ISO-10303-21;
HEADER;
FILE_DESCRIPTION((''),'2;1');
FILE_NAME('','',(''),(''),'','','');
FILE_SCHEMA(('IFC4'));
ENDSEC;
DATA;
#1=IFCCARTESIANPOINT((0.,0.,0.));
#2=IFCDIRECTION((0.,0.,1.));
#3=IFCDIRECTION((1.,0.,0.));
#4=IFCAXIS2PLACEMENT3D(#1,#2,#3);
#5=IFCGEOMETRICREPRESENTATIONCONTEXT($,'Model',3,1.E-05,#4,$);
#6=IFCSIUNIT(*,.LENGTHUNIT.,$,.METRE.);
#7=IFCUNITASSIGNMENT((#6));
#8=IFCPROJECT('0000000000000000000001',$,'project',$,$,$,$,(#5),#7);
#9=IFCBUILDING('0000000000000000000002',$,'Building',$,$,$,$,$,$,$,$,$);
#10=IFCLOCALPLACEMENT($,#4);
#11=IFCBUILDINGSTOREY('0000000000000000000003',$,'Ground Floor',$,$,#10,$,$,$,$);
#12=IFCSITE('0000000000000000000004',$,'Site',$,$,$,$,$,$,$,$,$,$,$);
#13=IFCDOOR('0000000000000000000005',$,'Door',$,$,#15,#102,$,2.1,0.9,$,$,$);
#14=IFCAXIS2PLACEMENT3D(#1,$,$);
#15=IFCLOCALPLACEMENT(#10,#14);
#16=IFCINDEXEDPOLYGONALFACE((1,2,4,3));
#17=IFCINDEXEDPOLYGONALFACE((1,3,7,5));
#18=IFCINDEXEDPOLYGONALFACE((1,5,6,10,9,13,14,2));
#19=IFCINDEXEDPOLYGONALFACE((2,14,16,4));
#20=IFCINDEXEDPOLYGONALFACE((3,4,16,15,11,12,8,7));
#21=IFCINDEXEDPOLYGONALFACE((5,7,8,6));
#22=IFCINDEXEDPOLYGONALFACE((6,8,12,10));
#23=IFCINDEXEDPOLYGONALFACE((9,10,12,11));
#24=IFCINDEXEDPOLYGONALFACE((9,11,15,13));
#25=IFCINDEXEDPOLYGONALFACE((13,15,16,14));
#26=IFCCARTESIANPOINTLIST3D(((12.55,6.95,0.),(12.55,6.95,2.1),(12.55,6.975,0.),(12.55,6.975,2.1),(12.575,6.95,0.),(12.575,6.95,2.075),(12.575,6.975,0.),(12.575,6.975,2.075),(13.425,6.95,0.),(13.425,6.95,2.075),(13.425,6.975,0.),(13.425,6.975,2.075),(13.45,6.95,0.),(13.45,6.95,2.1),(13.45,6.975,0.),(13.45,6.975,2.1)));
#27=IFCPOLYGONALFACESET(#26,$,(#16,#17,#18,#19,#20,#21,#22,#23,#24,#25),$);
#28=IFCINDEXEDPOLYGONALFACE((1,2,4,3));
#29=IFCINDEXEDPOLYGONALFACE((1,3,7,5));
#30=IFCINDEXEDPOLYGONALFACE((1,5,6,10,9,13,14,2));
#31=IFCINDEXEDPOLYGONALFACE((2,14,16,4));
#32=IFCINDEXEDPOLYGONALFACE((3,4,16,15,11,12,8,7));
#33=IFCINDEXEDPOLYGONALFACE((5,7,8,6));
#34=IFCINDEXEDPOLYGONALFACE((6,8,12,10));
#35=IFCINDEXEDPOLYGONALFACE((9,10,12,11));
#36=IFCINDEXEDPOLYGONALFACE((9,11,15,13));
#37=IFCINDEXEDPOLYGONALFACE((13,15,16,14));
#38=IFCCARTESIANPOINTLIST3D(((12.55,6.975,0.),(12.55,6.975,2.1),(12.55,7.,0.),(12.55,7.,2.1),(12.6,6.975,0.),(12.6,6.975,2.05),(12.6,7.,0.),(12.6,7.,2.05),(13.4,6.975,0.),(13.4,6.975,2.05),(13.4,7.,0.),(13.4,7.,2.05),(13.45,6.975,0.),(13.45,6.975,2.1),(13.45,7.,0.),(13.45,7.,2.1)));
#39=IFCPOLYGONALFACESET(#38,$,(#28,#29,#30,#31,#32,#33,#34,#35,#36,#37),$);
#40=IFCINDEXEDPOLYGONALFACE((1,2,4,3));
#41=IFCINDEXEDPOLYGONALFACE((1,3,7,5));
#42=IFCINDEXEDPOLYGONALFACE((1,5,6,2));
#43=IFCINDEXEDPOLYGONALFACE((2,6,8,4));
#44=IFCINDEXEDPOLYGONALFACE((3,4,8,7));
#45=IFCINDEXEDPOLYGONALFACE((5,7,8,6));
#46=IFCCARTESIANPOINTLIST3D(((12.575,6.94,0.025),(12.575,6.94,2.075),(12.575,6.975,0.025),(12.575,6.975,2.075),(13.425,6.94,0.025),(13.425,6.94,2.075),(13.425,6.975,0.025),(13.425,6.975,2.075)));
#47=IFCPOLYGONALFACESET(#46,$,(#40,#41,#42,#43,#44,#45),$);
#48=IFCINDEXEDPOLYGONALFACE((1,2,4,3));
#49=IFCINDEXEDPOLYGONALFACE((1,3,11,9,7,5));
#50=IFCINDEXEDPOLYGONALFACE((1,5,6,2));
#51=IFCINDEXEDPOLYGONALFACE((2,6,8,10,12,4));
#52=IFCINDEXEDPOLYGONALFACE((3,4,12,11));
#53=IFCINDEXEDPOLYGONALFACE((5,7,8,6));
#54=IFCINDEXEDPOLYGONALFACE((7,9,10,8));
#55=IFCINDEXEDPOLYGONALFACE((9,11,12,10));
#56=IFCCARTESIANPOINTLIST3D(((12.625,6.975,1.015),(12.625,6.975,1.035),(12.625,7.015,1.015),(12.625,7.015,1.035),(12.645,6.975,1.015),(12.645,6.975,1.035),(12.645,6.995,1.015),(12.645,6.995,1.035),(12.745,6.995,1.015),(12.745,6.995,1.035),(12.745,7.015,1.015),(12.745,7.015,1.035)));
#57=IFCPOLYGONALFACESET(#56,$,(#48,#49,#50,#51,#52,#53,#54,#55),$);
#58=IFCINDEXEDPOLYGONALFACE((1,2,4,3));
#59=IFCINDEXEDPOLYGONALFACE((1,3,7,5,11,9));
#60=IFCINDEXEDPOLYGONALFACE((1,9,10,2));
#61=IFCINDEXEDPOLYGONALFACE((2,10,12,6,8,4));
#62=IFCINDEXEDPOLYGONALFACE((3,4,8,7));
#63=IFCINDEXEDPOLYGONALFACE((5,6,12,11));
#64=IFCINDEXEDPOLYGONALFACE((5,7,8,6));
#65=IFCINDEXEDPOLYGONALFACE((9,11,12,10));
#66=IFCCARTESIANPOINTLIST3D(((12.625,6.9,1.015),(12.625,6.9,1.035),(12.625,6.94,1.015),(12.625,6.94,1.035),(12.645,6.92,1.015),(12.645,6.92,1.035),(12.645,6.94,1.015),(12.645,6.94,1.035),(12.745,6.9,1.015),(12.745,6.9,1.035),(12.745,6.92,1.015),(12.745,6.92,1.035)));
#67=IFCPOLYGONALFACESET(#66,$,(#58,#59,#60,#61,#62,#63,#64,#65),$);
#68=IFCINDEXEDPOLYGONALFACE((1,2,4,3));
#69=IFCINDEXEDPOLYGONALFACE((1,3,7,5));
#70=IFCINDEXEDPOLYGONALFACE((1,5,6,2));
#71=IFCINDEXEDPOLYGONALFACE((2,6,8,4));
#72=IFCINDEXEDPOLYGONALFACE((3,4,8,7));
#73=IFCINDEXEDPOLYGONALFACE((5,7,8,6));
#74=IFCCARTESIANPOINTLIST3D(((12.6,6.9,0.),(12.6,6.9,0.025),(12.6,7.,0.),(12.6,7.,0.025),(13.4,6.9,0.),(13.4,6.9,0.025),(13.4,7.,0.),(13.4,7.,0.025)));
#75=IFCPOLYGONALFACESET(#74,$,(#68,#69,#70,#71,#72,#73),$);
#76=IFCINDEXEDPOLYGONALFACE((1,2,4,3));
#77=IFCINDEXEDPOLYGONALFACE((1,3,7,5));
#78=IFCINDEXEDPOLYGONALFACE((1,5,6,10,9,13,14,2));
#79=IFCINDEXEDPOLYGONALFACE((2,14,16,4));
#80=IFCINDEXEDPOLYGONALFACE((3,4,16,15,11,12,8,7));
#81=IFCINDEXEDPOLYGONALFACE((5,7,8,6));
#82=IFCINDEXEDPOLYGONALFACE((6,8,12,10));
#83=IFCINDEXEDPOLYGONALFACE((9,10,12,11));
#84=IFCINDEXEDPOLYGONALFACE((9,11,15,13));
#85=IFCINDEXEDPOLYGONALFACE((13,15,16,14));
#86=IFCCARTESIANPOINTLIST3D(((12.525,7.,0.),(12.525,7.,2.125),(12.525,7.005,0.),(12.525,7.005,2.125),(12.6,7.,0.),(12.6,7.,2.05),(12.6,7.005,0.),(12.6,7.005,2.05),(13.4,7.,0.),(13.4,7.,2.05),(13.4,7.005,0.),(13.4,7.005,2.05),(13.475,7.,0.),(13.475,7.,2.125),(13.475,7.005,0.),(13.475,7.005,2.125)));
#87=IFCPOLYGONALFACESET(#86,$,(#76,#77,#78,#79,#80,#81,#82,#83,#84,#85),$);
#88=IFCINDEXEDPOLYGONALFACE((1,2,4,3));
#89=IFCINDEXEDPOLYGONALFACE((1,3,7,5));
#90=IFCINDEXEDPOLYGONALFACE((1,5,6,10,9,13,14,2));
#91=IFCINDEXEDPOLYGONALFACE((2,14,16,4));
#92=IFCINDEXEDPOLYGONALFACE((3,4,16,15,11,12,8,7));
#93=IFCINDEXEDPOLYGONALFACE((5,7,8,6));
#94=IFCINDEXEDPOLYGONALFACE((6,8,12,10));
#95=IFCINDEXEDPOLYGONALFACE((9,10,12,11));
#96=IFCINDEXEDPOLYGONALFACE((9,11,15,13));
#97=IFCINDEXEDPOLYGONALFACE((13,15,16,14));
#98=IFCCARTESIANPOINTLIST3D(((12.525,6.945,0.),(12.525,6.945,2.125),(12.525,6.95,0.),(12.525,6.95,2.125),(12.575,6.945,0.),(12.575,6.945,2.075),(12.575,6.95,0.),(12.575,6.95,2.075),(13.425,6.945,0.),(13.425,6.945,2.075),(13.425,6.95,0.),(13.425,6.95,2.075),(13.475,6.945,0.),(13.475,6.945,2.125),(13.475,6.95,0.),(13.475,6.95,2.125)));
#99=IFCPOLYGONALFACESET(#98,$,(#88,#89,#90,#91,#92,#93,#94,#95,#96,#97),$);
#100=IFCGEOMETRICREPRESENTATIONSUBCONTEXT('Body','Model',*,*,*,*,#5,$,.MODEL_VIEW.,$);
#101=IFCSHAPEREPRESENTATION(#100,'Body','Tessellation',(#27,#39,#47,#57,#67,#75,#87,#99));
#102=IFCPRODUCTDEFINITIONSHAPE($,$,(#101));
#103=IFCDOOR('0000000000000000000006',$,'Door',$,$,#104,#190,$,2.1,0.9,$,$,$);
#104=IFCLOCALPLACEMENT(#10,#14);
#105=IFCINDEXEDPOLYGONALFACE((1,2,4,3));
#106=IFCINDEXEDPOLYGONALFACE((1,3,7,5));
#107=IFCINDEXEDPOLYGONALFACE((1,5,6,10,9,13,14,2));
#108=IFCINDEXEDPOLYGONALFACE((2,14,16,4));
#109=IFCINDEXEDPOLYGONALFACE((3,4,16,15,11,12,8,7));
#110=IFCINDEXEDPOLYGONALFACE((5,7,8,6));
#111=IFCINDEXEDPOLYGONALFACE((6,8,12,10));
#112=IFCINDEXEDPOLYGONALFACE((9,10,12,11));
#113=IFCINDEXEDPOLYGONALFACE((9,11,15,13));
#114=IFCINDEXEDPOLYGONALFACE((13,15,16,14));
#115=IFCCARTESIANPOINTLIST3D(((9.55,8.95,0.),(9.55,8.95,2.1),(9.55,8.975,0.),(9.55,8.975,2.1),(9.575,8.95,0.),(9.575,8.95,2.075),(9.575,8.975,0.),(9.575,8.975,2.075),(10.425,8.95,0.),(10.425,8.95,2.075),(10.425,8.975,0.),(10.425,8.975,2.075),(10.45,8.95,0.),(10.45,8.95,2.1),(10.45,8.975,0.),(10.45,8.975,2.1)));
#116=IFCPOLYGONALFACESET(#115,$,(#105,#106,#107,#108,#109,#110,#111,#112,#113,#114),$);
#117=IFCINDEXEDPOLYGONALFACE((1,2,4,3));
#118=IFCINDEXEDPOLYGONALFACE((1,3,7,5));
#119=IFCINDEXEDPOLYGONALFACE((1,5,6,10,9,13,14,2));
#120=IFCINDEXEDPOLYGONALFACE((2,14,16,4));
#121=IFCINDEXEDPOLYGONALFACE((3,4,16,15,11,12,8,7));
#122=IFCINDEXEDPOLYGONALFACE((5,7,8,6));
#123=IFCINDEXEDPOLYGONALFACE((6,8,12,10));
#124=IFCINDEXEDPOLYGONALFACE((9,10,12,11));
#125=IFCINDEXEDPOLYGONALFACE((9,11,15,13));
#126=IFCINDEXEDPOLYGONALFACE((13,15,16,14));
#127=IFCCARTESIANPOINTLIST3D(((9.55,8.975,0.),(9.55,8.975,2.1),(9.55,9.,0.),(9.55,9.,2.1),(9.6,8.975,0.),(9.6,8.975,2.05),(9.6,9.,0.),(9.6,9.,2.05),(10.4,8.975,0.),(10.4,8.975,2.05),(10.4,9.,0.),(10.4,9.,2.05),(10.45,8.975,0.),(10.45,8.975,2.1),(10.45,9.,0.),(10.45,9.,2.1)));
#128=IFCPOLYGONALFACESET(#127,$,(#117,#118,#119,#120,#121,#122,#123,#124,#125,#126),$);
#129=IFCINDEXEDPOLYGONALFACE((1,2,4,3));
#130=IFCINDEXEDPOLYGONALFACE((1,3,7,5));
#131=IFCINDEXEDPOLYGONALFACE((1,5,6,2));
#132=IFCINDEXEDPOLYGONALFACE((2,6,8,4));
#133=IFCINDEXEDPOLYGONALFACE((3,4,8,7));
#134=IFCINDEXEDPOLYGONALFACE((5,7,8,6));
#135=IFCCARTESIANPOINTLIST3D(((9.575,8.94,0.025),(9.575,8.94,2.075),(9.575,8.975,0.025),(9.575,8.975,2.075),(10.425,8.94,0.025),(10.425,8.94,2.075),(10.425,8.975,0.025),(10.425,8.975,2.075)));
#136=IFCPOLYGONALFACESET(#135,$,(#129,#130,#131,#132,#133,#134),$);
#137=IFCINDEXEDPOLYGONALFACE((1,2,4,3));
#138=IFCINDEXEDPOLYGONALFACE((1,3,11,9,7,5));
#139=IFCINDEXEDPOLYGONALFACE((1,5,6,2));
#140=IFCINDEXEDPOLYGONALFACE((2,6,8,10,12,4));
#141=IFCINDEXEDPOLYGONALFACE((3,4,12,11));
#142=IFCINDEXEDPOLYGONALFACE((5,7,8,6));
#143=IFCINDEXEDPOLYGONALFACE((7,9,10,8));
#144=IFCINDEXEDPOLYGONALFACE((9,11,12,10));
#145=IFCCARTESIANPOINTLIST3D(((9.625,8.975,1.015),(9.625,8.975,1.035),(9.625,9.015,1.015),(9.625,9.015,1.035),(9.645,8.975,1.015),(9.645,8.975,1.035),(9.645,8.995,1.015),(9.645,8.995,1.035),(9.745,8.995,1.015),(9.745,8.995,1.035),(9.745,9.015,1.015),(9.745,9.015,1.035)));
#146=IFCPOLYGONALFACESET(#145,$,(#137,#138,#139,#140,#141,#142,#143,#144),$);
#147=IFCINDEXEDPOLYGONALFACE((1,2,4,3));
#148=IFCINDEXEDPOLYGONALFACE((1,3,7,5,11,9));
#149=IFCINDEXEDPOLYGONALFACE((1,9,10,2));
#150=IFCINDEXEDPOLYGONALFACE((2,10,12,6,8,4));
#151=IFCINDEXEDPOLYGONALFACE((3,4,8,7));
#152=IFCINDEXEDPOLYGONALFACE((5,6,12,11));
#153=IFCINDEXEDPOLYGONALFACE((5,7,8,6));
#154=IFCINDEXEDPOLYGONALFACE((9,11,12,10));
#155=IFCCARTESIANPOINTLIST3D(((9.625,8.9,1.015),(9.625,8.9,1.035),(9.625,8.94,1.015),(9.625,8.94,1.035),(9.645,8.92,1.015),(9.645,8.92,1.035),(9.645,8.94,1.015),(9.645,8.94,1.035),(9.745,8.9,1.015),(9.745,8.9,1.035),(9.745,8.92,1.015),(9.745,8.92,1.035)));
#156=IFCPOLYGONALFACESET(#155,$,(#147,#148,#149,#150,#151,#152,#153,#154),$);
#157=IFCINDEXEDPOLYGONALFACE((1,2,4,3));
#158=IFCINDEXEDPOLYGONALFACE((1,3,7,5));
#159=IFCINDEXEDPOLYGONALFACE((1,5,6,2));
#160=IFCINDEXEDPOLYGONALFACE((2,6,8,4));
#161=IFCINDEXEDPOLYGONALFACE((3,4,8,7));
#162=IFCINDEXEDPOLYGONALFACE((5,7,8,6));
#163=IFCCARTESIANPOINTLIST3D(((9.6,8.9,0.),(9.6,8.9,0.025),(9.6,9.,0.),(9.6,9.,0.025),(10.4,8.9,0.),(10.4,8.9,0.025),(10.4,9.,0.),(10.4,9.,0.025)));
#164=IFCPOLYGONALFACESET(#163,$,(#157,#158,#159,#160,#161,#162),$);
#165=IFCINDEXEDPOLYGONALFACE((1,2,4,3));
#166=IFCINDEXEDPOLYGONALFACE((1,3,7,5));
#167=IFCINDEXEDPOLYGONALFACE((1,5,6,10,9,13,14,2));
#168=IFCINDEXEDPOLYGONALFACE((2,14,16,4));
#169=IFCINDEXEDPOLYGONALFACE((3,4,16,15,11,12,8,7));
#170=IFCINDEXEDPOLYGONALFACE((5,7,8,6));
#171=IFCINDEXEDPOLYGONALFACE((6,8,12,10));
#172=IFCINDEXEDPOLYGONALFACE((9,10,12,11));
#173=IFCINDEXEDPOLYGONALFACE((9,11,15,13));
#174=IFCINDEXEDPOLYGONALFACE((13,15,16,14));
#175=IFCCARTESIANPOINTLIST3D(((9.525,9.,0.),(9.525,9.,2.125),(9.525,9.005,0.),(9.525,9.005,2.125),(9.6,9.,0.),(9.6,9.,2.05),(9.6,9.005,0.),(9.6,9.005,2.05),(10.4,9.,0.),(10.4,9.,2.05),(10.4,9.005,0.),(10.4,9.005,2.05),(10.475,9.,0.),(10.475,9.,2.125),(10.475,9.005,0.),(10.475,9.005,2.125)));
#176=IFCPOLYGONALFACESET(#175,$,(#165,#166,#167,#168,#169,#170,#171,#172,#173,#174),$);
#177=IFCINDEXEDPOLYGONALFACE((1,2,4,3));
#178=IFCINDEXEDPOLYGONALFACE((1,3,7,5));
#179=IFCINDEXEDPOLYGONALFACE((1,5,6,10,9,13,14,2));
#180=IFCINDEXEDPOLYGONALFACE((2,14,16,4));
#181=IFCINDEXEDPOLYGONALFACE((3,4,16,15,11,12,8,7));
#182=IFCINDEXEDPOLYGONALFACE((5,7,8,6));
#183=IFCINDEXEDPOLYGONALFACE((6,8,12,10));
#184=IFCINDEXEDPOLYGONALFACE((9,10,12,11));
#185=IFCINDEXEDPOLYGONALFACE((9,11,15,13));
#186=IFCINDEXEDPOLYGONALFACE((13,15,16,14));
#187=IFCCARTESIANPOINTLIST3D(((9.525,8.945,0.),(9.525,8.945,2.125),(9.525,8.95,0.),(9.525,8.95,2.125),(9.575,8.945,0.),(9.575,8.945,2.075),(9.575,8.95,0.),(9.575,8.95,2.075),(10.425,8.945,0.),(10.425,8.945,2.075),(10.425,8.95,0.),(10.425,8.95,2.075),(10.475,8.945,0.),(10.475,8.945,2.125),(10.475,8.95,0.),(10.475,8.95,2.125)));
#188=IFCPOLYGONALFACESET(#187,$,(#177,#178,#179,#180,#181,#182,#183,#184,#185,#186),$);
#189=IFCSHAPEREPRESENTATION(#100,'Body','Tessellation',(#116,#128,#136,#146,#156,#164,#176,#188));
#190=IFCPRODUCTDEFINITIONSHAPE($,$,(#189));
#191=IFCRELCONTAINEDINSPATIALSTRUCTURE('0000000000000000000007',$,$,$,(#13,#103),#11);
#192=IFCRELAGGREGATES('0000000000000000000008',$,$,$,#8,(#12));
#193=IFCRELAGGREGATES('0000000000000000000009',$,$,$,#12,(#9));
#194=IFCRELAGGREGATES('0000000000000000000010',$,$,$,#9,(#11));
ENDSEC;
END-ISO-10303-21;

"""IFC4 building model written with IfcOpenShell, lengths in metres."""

from ifc_helpers import new_model, si_unit, frame, origin_with_axes, place, context, subcontext, project, spatial, line, indexed_curve, outline, extrude, element, save


model = new_model("IFC4")

# Units and contexts
model_context = context("Model", 3, precision=1e-05, world=origin_with_axes())
body_context = subcontext(model_context, "Body", "Model", "MODEL_VIEW")
ifc_project = project(units=[si_unit("LENGTHUNIT", "METRE")], contexts=[model_context])

# Site, building, storey
site = spatial("IfcSite", under=ifc_project, Name="Site")
building = spatial("IfcBuilding", under=site, Name="Building")
storey_placement = place(None, origin_with_axes())
storey = spatial("IfcBuildingStorey", under=building, at=storey_placement, Name="Ground Floor")

# Doors
door_1_placement = place(storey_placement, frame((13.45, 7.0, 0.0), z_axis=(0.0, 0.0, 1.0), x_axis=(-1.0, 0.0, 0.0)))
element("IfcDoor", 1, at=door_1_placement, inside=storey, Name="Door", OverallHeight=2.1, OverallWidth=0.9, context=body_context, shape_type="SweptSolid", body=[
    extrude(outline(indexed_curve([(0.0, 0.0), (0.0, 2.1), (0.9, 2.1), (0.9, 0.0), (0.875, 0.0), (0.875, 2.075), (0.025, 2.075), (0.025, 0.0)], segments=[line(1, 2, 3, 4, 5, 6, 7, 8, 1)])), frame((0.0, 0.025, 0.0), z_axis=(0.0, -1.0, 0.0), x_axis=(1.0, 0.0, 0.0)), (0.0, 0.0, -1.0), 0.025),
    extrude(outline(indexed_curve([(0.0, 0.0), (0.0, 2.1), (0.9, 2.1), (0.9, 0.0), (0.85, 0.0), (0.85, 2.05), (0.05, 2.05), (0.05, 0.0)], segments=[line(1, 2, 3, 4, 5, 6, 7, 8, 1)])), frame((0.0, 0.0, 0.0), z_axis=(0.0, -1.0, 0.0), x_axis=(1.0, 0.0, 0.0)), (0.0, 0.0, -1.0), 0.025),
    extrude(outline(indexed_curve([(0.0, 0.0), (0.85, 0.0), (0.85, 0.035), (0.0, 0.035)], segments=[line(1, 2, 3, 4, 1)])), frame((0.025, 0.025, 0.025), z_axis=(0.0, 0.0, 1.0), x_axis=(1.0, 0.0, 0.0)), (0.0, 0.0, 1.0), 2.05),
    extrude(outline(indexed_curve([(0.0, 0.0), (0.0, -0.04), (-0.12, -0.04), (-0.12, -0.02), (-0.02, -0.02), (-0.02, 0.0)], segments=[line(1, 2, 3, 4, 5, 6, 1)])), frame((0.825, 0.025, 1.015), z_axis=(0.0, 0.0, 1.0), x_axis=(1.0, 0.0, 0.0)), (0.0, 0.0, 1.0), 0.02),
    extrude(outline(indexed_curve([(0.0, 0.0), (0.0, 0.04), (-0.12, 0.04), (-0.12, 0.02), (-0.02, 0.02), (-0.02, 0.0)], segments=[line(1, 2, 3, 4, 5, 6, 1)])), frame((0.825, 0.06, 1.015), z_axis=(0.0, 0.0, 1.0), x_axis=(1.0, 0.0, 0.0)), (0.0, 0.0, 1.0), 0.02),
    extrude(outline(indexed_curve([(0.0, 0.0), (0.8, 0.0), (0.8, 0.1), (0.0, 0.1)], segments=[line(1, 2, 3, 4, 1)])), frame((0.05, 0.0, 0.0), z_axis=(0.0, 0.0, 1.0), x_axis=(1.0, 0.0, 0.0)), (0.0, 0.0, 1.0), 0.025),
    extrude(outline(indexed_curve([(0.0, 0.0), (0.0, 2.125), (0.95, 2.125), (0.95, 0.0), (0.875, 0.0), (0.875, 2.05), (0.075, 2.05), (0.075, 0.0)], segments=[line(1, 2, 3, 4, 5, 6, 7, 8, 1)])), frame((-0.025, -0.005, 0.0), z_axis=(0.0, -1.0, 0.0), x_axis=(1.0, 0.0, 0.0)), (0.0, 0.0, -1.0), 0.005),
    extrude(outline(indexed_curve([(0.0, 0.0), (0.0, 2.125), (0.95, 2.125), (0.95, 0.0), (0.9, 0.0), (0.9, 2.075), (0.05, 2.075), (0.05, 0.0)], segments=[line(1, 2, 3, 4, 5, 6, 7, 8, 1)])), frame((-0.025, 0.05, 0.0), z_axis=(0.0, -1.0, 0.0), x_axis=(1.0, 0.0, 0.0)), (0.0, 0.0, -1.0), 0.005),
])
door_2_placement = place(storey_placement, frame((10.45, 9.0, 0.0), z_axis=(0.0, 0.0, 1.0), x_axis=(-1.0, 0.0, 0.0)))
element("IfcDoor", 2, at=door_2_placement, inside=storey, Name="Door", OverallHeight=2.1, OverallWidth=0.9, context=body_context, shape_type="SweptSolid", body=[
    extrude(outline(indexed_curve([(0.0, 0.0), (0.0, 2.1), (0.9, 2.1), (0.9, 0.0), (0.875, 0.0), (0.875, 2.075), (0.025, 2.075), (0.025, 0.0)], segments=[line(1, 2, 3, 4, 5, 6, 7, 8, 1)])), frame((0.0, 0.025, 0.0), z_axis=(0.0, -1.0, 0.0), x_axis=(1.0, 0.0, 0.0)), (0.0, 0.0, -1.0), 0.025),
    extrude(outline(indexed_curve([(0.0, 0.0), (0.0, 2.1), (0.9, 2.1), (0.9, 0.0), (0.85, 0.0), (0.85, 2.05), (0.05, 2.05), (0.05, 0.0)], segments=[line(1, 2, 3, 4, 5, 6, 7, 8, 1)])), frame((0.0, 0.0, 0.0), z_axis=(0.0, -1.0, 0.0), x_axis=(1.0, 0.0, 0.0)), (0.0, 0.0, -1.0), 0.025),
    extrude(outline(indexed_curve([(0.0, 0.0), (0.85, 0.0), (0.85, 0.035), (0.0, 0.035)], segments=[line(1, 2, 3, 4, 1)])), frame((0.025, 0.025, 0.025), z_axis=(0.0, 0.0, 1.0), x_axis=(1.0, 0.0, 0.0)), (0.0, 0.0, 1.0), 2.05),
    extrude(outline(indexed_curve([(0.0, 0.0), (0.0, -0.04), (-0.12, -0.04), (-0.12, -0.02), (-0.02, -0.02), (-0.02, 0.0)], segments=[line(1, 2, 3, 4, 5, 6, 1)])), frame((0.825, 0.025, 1.015), z_axis=(0.0, 0.0, 1.0), x_axis=(1.0, 0.0, 0.0)), (0.0, 0.0, 1.0), 0.02),
    extrude(outline(indexed_curve([(0.0, 0.0), (0.0, 0.04), (-0.12, 0.04), (-0.12, 0.02), (-0.02, 0.02), (-0.02, 0.0)], segments=[line(1, 2, 3, 4, 5, 6, 1)])), frame((0.825, 0.06, 1.015), z_axis=(0.0, 0.0, 1.0), x_axis=(1.0, 0.0, 0.0)), (0.0, 0.0, 1.0), 0.02),
    extrude(outline(indexed_curve([(0.0, 0.0), (0.8, 0.0), (0.8, 0.1), (0.0, 0.1)], segments=[line(1, 2, 3, 4, 1)])), frame((0.05, 0.0, 0.0), z_axis=(0.0, 0.0, 1.0), x_axis=(1.0, 0.0, 0.0)), (0.0, 0.0, 1.0), 0.025),
    extrude(outline(indexed_curve([(0.0, 0.0), (0.0, 2.125), (0.95, 2.125), (0.95, 0.0), (0.875, 0.0), (0.875, 2.05), (0.075, 2.05), (0.075, 0.0)], segments=[line(1, 2, 3, 4, 5, 6, 7, 8, 1)])), frame((-0.025, -0.005, 0.0), z_axis=(0.0, -1.0, 0.0), x_axis=(1.0, 0.0, 0.0)), (0.0, 0.0, -1.0), 0.005),
    extrude(outline(indexed_curve([(0.0, 0.0), (0.0, 2.125), (0.95, 2.125), (0.95, 0.0), (0.9, 0.0), (0.9, 2.075), (0.05, 2.075), (0.05, 0.0)], segments=[line(1, 2, 3, 4, 5, 6, 7, 8, 1)])), frame((-0.025, 0.05, 0.0), z_axis=(0.0, -1.0, 0.0), x_axis=(1.0, 0.0, 0.0)), (0.0, 0.0, -1.0), 0.005),
])

save(model, "model.ifc")
